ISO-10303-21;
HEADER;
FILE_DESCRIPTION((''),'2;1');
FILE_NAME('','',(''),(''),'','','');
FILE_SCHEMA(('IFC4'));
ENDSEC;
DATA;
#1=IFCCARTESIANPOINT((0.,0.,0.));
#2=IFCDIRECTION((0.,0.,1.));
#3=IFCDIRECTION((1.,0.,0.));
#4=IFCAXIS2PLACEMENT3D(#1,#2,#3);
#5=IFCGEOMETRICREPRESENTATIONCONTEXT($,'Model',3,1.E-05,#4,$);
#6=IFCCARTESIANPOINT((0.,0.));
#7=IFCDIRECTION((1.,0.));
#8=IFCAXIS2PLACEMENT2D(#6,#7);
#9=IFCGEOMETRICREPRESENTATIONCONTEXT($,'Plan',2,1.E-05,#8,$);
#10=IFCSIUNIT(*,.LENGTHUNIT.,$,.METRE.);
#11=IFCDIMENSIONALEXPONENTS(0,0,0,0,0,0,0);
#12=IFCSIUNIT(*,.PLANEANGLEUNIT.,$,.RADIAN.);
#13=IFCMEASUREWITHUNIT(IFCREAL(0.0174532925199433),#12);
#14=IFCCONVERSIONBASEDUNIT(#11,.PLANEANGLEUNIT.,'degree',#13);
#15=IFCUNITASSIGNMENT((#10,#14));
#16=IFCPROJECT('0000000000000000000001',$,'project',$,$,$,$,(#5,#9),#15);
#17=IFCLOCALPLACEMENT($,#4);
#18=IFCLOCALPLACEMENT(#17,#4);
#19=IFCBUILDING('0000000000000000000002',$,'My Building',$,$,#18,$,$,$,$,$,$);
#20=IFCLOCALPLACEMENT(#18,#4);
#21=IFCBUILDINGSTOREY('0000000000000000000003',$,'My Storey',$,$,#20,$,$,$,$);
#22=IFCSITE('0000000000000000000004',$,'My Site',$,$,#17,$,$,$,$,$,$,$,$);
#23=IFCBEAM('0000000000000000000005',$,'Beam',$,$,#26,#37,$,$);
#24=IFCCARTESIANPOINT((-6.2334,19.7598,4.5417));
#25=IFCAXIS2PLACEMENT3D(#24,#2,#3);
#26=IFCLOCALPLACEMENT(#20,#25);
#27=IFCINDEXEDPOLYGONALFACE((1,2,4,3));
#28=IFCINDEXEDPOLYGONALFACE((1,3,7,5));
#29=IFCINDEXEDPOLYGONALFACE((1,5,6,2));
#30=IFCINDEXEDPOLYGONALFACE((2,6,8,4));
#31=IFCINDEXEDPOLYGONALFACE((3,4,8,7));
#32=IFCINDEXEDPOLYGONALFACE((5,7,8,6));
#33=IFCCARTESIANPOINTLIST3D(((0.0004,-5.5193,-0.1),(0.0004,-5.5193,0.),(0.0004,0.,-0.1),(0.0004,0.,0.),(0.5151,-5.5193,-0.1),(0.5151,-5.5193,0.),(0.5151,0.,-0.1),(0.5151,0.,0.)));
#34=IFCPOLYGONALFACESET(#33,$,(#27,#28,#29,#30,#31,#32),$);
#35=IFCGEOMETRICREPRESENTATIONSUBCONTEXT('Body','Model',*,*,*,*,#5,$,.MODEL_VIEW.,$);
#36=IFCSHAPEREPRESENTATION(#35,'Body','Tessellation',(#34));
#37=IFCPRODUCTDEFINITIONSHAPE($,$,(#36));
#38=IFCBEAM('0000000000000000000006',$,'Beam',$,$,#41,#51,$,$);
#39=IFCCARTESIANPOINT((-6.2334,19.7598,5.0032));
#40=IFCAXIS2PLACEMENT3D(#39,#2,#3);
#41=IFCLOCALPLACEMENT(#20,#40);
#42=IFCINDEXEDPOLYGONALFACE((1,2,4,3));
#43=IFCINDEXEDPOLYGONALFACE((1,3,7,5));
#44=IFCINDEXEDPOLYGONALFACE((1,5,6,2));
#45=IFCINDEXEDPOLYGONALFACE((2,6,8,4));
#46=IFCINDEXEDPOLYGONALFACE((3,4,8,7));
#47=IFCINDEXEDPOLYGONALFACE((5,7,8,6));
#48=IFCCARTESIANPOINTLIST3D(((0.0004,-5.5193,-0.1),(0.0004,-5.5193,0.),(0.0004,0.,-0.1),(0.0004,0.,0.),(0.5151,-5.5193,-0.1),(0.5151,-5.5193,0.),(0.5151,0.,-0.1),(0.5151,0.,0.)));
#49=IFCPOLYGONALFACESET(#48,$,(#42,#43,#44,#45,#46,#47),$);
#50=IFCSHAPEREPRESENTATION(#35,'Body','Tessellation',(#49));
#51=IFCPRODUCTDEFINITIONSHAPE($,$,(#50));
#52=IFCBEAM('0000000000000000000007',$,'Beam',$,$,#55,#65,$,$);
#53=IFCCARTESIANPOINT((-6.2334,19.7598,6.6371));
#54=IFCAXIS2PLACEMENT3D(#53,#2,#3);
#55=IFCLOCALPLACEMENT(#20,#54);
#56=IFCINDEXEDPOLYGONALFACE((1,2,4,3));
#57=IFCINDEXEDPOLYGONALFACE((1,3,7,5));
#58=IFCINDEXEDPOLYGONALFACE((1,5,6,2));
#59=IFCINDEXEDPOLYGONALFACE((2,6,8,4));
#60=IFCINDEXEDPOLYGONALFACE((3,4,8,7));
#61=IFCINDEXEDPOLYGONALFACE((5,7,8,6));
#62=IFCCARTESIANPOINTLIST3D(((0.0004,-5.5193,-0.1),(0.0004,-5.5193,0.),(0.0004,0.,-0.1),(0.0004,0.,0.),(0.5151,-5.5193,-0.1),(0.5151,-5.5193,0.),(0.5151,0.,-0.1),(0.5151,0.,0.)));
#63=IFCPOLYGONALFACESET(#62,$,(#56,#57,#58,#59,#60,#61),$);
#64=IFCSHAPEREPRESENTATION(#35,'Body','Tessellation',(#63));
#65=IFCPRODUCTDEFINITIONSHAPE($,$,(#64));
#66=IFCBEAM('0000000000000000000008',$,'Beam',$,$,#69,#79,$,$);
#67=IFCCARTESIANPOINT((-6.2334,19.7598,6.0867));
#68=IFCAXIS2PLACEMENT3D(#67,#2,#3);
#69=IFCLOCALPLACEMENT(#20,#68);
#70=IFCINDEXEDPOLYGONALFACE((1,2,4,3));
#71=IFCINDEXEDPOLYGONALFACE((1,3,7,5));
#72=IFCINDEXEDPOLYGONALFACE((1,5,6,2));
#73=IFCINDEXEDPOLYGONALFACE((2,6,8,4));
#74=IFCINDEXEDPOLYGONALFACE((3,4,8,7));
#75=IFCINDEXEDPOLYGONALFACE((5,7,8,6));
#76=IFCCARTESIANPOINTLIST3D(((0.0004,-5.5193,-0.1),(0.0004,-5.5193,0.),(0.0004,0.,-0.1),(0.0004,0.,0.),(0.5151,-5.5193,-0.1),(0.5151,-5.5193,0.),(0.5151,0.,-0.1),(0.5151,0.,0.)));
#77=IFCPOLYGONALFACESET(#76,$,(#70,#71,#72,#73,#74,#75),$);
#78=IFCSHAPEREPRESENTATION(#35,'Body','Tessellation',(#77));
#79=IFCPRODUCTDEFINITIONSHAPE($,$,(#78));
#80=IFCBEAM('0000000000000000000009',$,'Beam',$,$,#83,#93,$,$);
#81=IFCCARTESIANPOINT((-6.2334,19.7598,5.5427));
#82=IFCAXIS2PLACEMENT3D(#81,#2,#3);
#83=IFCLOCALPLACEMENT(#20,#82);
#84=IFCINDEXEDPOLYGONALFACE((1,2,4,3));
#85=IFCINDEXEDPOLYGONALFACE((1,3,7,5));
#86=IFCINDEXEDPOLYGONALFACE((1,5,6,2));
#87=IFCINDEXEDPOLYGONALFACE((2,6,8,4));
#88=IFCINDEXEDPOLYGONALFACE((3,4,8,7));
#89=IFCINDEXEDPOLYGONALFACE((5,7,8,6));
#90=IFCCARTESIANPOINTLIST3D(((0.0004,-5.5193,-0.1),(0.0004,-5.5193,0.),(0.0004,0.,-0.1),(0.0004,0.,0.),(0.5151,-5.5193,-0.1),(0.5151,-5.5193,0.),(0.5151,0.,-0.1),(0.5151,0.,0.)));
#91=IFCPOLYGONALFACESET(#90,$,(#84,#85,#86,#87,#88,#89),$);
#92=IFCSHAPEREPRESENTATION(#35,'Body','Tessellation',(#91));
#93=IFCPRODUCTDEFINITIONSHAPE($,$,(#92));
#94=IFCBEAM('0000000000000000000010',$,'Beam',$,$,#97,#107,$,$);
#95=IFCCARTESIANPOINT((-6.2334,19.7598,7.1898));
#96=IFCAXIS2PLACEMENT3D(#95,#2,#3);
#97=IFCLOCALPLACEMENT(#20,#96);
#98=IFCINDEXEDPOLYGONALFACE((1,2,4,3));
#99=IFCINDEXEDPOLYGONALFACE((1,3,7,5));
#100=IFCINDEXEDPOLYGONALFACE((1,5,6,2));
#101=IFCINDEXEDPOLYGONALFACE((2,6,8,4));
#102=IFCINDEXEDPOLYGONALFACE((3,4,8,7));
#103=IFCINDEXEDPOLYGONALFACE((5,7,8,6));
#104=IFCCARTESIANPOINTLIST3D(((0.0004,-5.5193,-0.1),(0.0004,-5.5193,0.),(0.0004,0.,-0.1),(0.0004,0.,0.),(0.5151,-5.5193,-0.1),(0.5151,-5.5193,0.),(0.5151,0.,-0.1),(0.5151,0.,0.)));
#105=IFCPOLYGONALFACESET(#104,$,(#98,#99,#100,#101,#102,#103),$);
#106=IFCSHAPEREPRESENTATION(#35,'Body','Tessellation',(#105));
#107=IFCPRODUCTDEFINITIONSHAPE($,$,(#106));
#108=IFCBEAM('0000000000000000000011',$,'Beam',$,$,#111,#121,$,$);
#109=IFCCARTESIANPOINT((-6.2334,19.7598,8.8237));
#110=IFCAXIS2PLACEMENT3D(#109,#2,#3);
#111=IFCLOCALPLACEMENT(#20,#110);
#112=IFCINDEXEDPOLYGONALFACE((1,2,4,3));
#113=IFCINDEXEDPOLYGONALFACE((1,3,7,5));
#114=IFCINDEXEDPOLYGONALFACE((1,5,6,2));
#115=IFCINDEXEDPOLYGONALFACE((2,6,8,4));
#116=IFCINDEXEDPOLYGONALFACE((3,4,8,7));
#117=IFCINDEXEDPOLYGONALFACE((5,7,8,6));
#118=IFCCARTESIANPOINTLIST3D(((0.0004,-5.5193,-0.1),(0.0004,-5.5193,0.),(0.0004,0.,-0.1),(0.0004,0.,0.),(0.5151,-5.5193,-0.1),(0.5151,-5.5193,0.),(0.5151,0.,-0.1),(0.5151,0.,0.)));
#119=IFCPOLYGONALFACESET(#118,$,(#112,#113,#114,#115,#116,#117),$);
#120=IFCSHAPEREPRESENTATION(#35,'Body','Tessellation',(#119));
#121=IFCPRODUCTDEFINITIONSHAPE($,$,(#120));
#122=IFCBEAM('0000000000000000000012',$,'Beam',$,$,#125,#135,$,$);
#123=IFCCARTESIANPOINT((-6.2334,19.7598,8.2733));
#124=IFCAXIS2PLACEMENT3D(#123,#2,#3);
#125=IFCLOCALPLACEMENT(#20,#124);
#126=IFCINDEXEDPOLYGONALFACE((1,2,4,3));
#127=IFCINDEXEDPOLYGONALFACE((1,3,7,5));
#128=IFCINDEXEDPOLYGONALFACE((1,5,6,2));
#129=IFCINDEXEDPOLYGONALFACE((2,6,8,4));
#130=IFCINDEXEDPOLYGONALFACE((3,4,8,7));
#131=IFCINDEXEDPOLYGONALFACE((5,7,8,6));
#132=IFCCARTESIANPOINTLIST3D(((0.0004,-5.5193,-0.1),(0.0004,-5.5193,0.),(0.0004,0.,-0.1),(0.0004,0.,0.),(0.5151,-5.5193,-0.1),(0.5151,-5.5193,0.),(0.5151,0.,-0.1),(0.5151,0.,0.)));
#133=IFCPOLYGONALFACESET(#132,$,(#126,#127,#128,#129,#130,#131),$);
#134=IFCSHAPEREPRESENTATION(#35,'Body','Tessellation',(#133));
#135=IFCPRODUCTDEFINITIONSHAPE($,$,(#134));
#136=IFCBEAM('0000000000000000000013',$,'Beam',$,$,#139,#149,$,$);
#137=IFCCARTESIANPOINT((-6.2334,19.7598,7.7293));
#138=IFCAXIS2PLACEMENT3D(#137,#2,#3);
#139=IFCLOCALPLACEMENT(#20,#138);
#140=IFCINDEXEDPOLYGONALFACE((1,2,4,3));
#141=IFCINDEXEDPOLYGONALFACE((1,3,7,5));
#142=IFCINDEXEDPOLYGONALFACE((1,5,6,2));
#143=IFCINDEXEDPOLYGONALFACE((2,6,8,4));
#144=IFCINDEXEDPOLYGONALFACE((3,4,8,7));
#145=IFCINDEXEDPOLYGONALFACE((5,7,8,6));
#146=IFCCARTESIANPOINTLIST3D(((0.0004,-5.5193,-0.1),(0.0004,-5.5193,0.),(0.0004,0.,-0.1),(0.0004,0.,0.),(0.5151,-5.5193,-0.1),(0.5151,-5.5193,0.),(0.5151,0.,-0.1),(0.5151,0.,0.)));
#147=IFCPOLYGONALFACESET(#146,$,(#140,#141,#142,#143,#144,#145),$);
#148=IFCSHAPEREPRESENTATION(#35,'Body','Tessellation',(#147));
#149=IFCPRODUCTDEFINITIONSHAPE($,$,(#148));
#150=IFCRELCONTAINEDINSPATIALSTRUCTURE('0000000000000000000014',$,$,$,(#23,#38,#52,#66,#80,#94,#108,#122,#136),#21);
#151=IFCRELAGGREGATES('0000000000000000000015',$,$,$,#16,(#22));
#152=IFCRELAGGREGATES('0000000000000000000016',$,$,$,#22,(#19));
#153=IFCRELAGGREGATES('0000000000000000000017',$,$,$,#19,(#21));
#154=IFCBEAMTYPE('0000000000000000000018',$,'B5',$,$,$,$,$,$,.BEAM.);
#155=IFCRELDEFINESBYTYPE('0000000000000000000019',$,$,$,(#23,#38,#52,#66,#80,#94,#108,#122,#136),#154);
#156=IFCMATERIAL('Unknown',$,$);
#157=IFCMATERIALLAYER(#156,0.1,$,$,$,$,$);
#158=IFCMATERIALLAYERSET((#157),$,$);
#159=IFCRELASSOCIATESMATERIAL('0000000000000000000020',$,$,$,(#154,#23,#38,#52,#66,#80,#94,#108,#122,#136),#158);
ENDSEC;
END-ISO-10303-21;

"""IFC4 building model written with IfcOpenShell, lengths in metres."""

from ifc_helpers import new_model, entity, si_unit, converted_unit, frame, origin_with_axes, origin_2d_with_axis, place, context, subcontext, project, spatial, indexed_curve, outline, extrude, material, layer, layer_set, layer_usage, type_object, element, save


model = new_model("IFC4")

# Units and contexts
model_context = context("Model", 3, precision=1e-05, world=origin_with_axes())
plan_context = context("Plan", 2, precision=1e-05, world=origin_2d_with_axis())
body_context = subcontext(model_context, "Body", "Model", "MODEL_VIEW")
ifc_project = project(units=[si_unit("LENGTHUNIT", "METRE"), converted_unit("PLANEANGLEUNIT", "degree", entity("IfcReal", 0.0174532925199433), si_unit("PLANEANGLEUNIT", "RADIAN"), dimensions=[0, 0, 0, 0, 0, 0, 0])], contexts=[model_context, plan_context])

# Site, building, storey
site_placement = place(None, origin_with_axes())
site = spatial("IfcSite", under=ifc_project, at=site_placement, Name="My Site")
building_placement = place(site_placement, origin_with_axes())
building = spatial("IfcBuilding", under=site, at=building_placement, Name="My Building")
storey_placement = place(building_placement, origin_with_axes())
storey = spatial("IfcBuildingStorey", under=building, at=storey_placement, Name="My Storey")

# Beams
ifc_material = material(Name="Unknown")
ifc_layer = layer(ifc_material, 0.1)
ifc_layer_set = layer_set([ifc_layer])
ifc_layer_usage_1 = layer_usage(ifc_layer_set, "AXIS3", "POSITIVE", -0.1)
beam_type_1 = type_object("IfcBeamType", Name="B5", PredefinedType="BEAM", material=ifc_layer_set)
beam_1_placement = place(storey_placement, frame((-6.2334, 19.7598, 4.5417), z_axis=(0.0, 0.0, 1.0), x_axis=(1.0, 0.0, 0.0)))
element("IfcBeam", 1, at=beam_1_placement, inside=storey, type_object=beam_type_1, material=ifc_layer_usage_1, Name="Beam", context=body_context, shape_type="SweptSolid", body=[
    extrude(outline(indexed_curve([(0.0, 0.0), (0.5151, 0.0), (0.5151, -5.5193), (0.0004, -5.5193), (0.0004, 0.0), (0.0, 0.0)])), frame((0.0, 0.0, -0.1), z_axis=(0.0, 0.0, 1.0), x_axis=(1.0, 0.0, 0.0)), (0.0, 0.0, 1.0), 0.1),
])
ifc_layer_usage_2 = layer_usage(ifc_layer_set, "AXIS3", "POSITIVE", -0.1)
beam_2_placement = place(storey_placement, frame((-6.2334, 19.7598, 5.0032), z_axis=(0.0, 0.0, 1.0), x_axis=(1.0, 0.0, 0.0)))
element("IfcBeam", 2, at=beam_2_placement, inside=storey, type_object=beam_type_1, material=ifc_layer_usage_2, Name="Beam", context=body_context, shape_type="SweptSolid", body=[
    extrude(outline(indexed_curve([(0.0, 0.0), (0.5151, 0.0), (0.5151, -5.5193), (0.0004, -5.5193), (0.0004, 0.0), (0.0, 0.0)])), frame((0.0, 0.0, -0.1), z_axis=(0.0, 0.0, 1.0), x_axis=(1.0, 0.0, 0.0)), (0.0, 0.0, 1.0), 0.1),
])
ifc_layer_usage_3 = layer_usage(ifc_layer_set, "AXIS3", "POSITIVE", -0.1)
beam_3_placement = place(storey_placement, frame((-6.2334, 19.7598, 6.6371), z_axis=(0.0, 0.0, 1.0), x_axis=(1.0, 0.0, 0.0)))
element("IfcBeam", 3, at=beam_3_placement, inside=storey, type_object=beam_type_1, material=ifc_layer_usage_3, Name="Beam", context=body_context, shape_type="SweptSolid", body=[
    extrude(outline(indexed_curve([(0.0, 0.0), (0.5151, 0.0), (0.5151, -5.5193), (0.0004, -5.5193), (0.0004, 0.0), (0.0, 0.0)])), frame((0.0, 0.0, -0.1), z_axis=(0.0, 0.0, 1.0), x_axis=(1.0, 0.0, 0.0)), (0.0, 0.0, 1.0), 0.1),
])
ifc_layer_usage_4 = layer_usage(ifc_layer_set, "AXIS3", "POSITIVE", -0.1)
beam_4_placement = place(storey_placement, frame((-6.2334, 19.7598, 6.0867), z_axis=(0.0, 0.0, 1.0), x_axis=(1.0, 0.0, 0.0)))
element("IfcBeam", 4, at=beam_4_placement, inside=storey, type_object=beam_type_1, material=ifc_layer_usage_4, Name="Beam", context=body_context, shape_type="SweptSolid", body=[
    extrude(outline(indexed_curve([(0.0, 0.0), (0.5151, 0.0), (0.5151, -5.5193), (0.0004, -5.5193), (0.0004, 0.0), (0.0, 0.0)])), frame((0.0, 0.0, -0.1), z_axis=(0.0, 0.0, 1.0), x_axis=(1.0, 0.0, 0.0)), (0.0, 0.0, 1.0), 0.1),
])
ifc_layer_usage_5 = layer_usage(ifc_layer_set, "AXIS3", "POSITIVE", -0.1)
beam_5_placement = place(storey_placement, frame((-6.2334, 19.7598, 5.5427), z_axis=(0.0, 0.0, 1.0), x_axis=(1.0, 0.0, 0.0)))
element("IfcBeam", 5, at=beam_5_placement, inside=storey, type_object=beam_type_1, material=ifc_layer_usage_5, Name="Beam", context=body_context, shape_type="SweptSolid", body=[
    extrude(outline(indexed_curve([(0.0, 0.0), (0.5151, 0.0), (0.5151, -5.5193), (0.0004, -5.5193), (0.0004, 0.0), (0.0, 0.0)])), frame((0.0, 0.0, -0.1), z_axis=(0.0, 0.0, 1.0), x_axis=(1.0, 0.0, 0.0)), (0.0, 0.0, 1.0), 0.1),
])
ifc_layer_usage_6 = layer_usage(ifc_layer_set, "AXIS3", "POSITIVE", -0.1)
beam_6_placement = place(storey_placement, frame((-6.2334, 19.7598, 7.1898), z_axis=(0.0, 0.0, 1.0), x_axis=(1.0, 0.0, 0.0)))
element("IfcBeam", 6, at=beam_6_placement, inside=storey, type_object=beam_type_1, material=ifc_layer_usage_6, Name="Beam", context=body_context, shape_type="SweptSolid", body=[
    extrude(outline(indexed_curve([(0.0, 0.0), (0.5151, 0.0), (0.5151, -5.5193), (0.0004, -5.5193), (0.0004, 0.0), (0.0, 0.0)])), frame((0.0, 0.0, -0.1), z_axis=(0.0, 0.0, 1.0), x_axis=(1.0, 0.0, 0.0)), (0.0, 0.0, 1.0), 0.1),
])
ifc_layer_usage_7 = layer_usage(ifc_layer_set, "AXIS3", "POSITIVE", -0.1)
beam_7_placement = place(storey_placement, frame((-6.2334, 19.7598, 8.8237), z_axis=(0.0, 0.0, 1.0), x_axis=(1.0, 0.0, 0.0)))
element("IfcBeam", 7, at=beam_7_placement, inside=storey, type_object=beam_type_1, material=ifc_layer_usage_7, Name="Beam", context=body_context, shape_type="SweptSolid", body=[
    extrude(outline(indexed_curve([(0.0, 0.0), (0.5151, 0.0), (0.5151, -5.5193), (0.0004, -5.5193), (0.0004, 0.0), (0.0, 0.0)])), frame((0.0, 0.0, -0.1), z_axis=(0.0, 0.0, 1.0), x_axis=(1.0, 0.0, 0.0)), (0.0, 0.0, 1.0), 0.1),
])
ifc_layer_usage_8 = layer_usage(ifc_layer_set, "AXIS3", "POSITIVE", -0.1)
beam_8_placement = place(storey_placement, frame((-6.2334, 19.7598, 8.2733), z_axis=(0.0, 0.0, 1.0), x_axis=(1.0, 0.0, 0.0)))
element("IfcBeam", 8, at=beam_8_placement, inside=storey, type_object=beam_type_1, material=ifc_layer_usage_8, Name="Beam", context=body_context, shape_type="SweptSolid", body=[
    extrude(outline(indexed_curve([(0.0, 0.0), (0.5151, 0.0), (0.5151, -5.5193), (0.0004, -5.5193), (0.0004, 0.0), (0.0, 0.0)])), frame((0.0, 0.0, -0.1), z_axis=(0.0, 0.0, 1.0), x_axis=(1.0, 0.0, 0.0)), (0.0, 0.0, 1.0), 0.1),
])
ifc_layer_usage_9 = layer_usage(ifc_layer_set, "AXIS3", "POSITIVE", -0.1)
beam_9_placement = place(storey_placement, frame((-6.2334, 19.7598, 7.7293), z_axis=(0.0, 0.0, 1.0), x_axis=(1.0, 0.0, 0.0)))
element("IfcBeam", 9, at=beam_9_placement, inside=storey, type_object=beam_type_1, material=ifc_layer_usage_9, Name="Beam", context=body_context, shape_type="SweptSolid", body=[
    extrude(outline(indexed_curve([(0.0, 0.0), (0.5151, 0.0), (0.5151, -5.5193), (0.0004, -5.5193), (0.0004, 0.0), (0.0, 0.0)])), frame((0.0, 0.0, -0.1), z_axis=(0.0, 0.0, 1.0), x_axis=(1.0, 0.0, 0.0)), (0.0, 0.0, 1.0), 0.1),
])

save(model, "model.ifc")
